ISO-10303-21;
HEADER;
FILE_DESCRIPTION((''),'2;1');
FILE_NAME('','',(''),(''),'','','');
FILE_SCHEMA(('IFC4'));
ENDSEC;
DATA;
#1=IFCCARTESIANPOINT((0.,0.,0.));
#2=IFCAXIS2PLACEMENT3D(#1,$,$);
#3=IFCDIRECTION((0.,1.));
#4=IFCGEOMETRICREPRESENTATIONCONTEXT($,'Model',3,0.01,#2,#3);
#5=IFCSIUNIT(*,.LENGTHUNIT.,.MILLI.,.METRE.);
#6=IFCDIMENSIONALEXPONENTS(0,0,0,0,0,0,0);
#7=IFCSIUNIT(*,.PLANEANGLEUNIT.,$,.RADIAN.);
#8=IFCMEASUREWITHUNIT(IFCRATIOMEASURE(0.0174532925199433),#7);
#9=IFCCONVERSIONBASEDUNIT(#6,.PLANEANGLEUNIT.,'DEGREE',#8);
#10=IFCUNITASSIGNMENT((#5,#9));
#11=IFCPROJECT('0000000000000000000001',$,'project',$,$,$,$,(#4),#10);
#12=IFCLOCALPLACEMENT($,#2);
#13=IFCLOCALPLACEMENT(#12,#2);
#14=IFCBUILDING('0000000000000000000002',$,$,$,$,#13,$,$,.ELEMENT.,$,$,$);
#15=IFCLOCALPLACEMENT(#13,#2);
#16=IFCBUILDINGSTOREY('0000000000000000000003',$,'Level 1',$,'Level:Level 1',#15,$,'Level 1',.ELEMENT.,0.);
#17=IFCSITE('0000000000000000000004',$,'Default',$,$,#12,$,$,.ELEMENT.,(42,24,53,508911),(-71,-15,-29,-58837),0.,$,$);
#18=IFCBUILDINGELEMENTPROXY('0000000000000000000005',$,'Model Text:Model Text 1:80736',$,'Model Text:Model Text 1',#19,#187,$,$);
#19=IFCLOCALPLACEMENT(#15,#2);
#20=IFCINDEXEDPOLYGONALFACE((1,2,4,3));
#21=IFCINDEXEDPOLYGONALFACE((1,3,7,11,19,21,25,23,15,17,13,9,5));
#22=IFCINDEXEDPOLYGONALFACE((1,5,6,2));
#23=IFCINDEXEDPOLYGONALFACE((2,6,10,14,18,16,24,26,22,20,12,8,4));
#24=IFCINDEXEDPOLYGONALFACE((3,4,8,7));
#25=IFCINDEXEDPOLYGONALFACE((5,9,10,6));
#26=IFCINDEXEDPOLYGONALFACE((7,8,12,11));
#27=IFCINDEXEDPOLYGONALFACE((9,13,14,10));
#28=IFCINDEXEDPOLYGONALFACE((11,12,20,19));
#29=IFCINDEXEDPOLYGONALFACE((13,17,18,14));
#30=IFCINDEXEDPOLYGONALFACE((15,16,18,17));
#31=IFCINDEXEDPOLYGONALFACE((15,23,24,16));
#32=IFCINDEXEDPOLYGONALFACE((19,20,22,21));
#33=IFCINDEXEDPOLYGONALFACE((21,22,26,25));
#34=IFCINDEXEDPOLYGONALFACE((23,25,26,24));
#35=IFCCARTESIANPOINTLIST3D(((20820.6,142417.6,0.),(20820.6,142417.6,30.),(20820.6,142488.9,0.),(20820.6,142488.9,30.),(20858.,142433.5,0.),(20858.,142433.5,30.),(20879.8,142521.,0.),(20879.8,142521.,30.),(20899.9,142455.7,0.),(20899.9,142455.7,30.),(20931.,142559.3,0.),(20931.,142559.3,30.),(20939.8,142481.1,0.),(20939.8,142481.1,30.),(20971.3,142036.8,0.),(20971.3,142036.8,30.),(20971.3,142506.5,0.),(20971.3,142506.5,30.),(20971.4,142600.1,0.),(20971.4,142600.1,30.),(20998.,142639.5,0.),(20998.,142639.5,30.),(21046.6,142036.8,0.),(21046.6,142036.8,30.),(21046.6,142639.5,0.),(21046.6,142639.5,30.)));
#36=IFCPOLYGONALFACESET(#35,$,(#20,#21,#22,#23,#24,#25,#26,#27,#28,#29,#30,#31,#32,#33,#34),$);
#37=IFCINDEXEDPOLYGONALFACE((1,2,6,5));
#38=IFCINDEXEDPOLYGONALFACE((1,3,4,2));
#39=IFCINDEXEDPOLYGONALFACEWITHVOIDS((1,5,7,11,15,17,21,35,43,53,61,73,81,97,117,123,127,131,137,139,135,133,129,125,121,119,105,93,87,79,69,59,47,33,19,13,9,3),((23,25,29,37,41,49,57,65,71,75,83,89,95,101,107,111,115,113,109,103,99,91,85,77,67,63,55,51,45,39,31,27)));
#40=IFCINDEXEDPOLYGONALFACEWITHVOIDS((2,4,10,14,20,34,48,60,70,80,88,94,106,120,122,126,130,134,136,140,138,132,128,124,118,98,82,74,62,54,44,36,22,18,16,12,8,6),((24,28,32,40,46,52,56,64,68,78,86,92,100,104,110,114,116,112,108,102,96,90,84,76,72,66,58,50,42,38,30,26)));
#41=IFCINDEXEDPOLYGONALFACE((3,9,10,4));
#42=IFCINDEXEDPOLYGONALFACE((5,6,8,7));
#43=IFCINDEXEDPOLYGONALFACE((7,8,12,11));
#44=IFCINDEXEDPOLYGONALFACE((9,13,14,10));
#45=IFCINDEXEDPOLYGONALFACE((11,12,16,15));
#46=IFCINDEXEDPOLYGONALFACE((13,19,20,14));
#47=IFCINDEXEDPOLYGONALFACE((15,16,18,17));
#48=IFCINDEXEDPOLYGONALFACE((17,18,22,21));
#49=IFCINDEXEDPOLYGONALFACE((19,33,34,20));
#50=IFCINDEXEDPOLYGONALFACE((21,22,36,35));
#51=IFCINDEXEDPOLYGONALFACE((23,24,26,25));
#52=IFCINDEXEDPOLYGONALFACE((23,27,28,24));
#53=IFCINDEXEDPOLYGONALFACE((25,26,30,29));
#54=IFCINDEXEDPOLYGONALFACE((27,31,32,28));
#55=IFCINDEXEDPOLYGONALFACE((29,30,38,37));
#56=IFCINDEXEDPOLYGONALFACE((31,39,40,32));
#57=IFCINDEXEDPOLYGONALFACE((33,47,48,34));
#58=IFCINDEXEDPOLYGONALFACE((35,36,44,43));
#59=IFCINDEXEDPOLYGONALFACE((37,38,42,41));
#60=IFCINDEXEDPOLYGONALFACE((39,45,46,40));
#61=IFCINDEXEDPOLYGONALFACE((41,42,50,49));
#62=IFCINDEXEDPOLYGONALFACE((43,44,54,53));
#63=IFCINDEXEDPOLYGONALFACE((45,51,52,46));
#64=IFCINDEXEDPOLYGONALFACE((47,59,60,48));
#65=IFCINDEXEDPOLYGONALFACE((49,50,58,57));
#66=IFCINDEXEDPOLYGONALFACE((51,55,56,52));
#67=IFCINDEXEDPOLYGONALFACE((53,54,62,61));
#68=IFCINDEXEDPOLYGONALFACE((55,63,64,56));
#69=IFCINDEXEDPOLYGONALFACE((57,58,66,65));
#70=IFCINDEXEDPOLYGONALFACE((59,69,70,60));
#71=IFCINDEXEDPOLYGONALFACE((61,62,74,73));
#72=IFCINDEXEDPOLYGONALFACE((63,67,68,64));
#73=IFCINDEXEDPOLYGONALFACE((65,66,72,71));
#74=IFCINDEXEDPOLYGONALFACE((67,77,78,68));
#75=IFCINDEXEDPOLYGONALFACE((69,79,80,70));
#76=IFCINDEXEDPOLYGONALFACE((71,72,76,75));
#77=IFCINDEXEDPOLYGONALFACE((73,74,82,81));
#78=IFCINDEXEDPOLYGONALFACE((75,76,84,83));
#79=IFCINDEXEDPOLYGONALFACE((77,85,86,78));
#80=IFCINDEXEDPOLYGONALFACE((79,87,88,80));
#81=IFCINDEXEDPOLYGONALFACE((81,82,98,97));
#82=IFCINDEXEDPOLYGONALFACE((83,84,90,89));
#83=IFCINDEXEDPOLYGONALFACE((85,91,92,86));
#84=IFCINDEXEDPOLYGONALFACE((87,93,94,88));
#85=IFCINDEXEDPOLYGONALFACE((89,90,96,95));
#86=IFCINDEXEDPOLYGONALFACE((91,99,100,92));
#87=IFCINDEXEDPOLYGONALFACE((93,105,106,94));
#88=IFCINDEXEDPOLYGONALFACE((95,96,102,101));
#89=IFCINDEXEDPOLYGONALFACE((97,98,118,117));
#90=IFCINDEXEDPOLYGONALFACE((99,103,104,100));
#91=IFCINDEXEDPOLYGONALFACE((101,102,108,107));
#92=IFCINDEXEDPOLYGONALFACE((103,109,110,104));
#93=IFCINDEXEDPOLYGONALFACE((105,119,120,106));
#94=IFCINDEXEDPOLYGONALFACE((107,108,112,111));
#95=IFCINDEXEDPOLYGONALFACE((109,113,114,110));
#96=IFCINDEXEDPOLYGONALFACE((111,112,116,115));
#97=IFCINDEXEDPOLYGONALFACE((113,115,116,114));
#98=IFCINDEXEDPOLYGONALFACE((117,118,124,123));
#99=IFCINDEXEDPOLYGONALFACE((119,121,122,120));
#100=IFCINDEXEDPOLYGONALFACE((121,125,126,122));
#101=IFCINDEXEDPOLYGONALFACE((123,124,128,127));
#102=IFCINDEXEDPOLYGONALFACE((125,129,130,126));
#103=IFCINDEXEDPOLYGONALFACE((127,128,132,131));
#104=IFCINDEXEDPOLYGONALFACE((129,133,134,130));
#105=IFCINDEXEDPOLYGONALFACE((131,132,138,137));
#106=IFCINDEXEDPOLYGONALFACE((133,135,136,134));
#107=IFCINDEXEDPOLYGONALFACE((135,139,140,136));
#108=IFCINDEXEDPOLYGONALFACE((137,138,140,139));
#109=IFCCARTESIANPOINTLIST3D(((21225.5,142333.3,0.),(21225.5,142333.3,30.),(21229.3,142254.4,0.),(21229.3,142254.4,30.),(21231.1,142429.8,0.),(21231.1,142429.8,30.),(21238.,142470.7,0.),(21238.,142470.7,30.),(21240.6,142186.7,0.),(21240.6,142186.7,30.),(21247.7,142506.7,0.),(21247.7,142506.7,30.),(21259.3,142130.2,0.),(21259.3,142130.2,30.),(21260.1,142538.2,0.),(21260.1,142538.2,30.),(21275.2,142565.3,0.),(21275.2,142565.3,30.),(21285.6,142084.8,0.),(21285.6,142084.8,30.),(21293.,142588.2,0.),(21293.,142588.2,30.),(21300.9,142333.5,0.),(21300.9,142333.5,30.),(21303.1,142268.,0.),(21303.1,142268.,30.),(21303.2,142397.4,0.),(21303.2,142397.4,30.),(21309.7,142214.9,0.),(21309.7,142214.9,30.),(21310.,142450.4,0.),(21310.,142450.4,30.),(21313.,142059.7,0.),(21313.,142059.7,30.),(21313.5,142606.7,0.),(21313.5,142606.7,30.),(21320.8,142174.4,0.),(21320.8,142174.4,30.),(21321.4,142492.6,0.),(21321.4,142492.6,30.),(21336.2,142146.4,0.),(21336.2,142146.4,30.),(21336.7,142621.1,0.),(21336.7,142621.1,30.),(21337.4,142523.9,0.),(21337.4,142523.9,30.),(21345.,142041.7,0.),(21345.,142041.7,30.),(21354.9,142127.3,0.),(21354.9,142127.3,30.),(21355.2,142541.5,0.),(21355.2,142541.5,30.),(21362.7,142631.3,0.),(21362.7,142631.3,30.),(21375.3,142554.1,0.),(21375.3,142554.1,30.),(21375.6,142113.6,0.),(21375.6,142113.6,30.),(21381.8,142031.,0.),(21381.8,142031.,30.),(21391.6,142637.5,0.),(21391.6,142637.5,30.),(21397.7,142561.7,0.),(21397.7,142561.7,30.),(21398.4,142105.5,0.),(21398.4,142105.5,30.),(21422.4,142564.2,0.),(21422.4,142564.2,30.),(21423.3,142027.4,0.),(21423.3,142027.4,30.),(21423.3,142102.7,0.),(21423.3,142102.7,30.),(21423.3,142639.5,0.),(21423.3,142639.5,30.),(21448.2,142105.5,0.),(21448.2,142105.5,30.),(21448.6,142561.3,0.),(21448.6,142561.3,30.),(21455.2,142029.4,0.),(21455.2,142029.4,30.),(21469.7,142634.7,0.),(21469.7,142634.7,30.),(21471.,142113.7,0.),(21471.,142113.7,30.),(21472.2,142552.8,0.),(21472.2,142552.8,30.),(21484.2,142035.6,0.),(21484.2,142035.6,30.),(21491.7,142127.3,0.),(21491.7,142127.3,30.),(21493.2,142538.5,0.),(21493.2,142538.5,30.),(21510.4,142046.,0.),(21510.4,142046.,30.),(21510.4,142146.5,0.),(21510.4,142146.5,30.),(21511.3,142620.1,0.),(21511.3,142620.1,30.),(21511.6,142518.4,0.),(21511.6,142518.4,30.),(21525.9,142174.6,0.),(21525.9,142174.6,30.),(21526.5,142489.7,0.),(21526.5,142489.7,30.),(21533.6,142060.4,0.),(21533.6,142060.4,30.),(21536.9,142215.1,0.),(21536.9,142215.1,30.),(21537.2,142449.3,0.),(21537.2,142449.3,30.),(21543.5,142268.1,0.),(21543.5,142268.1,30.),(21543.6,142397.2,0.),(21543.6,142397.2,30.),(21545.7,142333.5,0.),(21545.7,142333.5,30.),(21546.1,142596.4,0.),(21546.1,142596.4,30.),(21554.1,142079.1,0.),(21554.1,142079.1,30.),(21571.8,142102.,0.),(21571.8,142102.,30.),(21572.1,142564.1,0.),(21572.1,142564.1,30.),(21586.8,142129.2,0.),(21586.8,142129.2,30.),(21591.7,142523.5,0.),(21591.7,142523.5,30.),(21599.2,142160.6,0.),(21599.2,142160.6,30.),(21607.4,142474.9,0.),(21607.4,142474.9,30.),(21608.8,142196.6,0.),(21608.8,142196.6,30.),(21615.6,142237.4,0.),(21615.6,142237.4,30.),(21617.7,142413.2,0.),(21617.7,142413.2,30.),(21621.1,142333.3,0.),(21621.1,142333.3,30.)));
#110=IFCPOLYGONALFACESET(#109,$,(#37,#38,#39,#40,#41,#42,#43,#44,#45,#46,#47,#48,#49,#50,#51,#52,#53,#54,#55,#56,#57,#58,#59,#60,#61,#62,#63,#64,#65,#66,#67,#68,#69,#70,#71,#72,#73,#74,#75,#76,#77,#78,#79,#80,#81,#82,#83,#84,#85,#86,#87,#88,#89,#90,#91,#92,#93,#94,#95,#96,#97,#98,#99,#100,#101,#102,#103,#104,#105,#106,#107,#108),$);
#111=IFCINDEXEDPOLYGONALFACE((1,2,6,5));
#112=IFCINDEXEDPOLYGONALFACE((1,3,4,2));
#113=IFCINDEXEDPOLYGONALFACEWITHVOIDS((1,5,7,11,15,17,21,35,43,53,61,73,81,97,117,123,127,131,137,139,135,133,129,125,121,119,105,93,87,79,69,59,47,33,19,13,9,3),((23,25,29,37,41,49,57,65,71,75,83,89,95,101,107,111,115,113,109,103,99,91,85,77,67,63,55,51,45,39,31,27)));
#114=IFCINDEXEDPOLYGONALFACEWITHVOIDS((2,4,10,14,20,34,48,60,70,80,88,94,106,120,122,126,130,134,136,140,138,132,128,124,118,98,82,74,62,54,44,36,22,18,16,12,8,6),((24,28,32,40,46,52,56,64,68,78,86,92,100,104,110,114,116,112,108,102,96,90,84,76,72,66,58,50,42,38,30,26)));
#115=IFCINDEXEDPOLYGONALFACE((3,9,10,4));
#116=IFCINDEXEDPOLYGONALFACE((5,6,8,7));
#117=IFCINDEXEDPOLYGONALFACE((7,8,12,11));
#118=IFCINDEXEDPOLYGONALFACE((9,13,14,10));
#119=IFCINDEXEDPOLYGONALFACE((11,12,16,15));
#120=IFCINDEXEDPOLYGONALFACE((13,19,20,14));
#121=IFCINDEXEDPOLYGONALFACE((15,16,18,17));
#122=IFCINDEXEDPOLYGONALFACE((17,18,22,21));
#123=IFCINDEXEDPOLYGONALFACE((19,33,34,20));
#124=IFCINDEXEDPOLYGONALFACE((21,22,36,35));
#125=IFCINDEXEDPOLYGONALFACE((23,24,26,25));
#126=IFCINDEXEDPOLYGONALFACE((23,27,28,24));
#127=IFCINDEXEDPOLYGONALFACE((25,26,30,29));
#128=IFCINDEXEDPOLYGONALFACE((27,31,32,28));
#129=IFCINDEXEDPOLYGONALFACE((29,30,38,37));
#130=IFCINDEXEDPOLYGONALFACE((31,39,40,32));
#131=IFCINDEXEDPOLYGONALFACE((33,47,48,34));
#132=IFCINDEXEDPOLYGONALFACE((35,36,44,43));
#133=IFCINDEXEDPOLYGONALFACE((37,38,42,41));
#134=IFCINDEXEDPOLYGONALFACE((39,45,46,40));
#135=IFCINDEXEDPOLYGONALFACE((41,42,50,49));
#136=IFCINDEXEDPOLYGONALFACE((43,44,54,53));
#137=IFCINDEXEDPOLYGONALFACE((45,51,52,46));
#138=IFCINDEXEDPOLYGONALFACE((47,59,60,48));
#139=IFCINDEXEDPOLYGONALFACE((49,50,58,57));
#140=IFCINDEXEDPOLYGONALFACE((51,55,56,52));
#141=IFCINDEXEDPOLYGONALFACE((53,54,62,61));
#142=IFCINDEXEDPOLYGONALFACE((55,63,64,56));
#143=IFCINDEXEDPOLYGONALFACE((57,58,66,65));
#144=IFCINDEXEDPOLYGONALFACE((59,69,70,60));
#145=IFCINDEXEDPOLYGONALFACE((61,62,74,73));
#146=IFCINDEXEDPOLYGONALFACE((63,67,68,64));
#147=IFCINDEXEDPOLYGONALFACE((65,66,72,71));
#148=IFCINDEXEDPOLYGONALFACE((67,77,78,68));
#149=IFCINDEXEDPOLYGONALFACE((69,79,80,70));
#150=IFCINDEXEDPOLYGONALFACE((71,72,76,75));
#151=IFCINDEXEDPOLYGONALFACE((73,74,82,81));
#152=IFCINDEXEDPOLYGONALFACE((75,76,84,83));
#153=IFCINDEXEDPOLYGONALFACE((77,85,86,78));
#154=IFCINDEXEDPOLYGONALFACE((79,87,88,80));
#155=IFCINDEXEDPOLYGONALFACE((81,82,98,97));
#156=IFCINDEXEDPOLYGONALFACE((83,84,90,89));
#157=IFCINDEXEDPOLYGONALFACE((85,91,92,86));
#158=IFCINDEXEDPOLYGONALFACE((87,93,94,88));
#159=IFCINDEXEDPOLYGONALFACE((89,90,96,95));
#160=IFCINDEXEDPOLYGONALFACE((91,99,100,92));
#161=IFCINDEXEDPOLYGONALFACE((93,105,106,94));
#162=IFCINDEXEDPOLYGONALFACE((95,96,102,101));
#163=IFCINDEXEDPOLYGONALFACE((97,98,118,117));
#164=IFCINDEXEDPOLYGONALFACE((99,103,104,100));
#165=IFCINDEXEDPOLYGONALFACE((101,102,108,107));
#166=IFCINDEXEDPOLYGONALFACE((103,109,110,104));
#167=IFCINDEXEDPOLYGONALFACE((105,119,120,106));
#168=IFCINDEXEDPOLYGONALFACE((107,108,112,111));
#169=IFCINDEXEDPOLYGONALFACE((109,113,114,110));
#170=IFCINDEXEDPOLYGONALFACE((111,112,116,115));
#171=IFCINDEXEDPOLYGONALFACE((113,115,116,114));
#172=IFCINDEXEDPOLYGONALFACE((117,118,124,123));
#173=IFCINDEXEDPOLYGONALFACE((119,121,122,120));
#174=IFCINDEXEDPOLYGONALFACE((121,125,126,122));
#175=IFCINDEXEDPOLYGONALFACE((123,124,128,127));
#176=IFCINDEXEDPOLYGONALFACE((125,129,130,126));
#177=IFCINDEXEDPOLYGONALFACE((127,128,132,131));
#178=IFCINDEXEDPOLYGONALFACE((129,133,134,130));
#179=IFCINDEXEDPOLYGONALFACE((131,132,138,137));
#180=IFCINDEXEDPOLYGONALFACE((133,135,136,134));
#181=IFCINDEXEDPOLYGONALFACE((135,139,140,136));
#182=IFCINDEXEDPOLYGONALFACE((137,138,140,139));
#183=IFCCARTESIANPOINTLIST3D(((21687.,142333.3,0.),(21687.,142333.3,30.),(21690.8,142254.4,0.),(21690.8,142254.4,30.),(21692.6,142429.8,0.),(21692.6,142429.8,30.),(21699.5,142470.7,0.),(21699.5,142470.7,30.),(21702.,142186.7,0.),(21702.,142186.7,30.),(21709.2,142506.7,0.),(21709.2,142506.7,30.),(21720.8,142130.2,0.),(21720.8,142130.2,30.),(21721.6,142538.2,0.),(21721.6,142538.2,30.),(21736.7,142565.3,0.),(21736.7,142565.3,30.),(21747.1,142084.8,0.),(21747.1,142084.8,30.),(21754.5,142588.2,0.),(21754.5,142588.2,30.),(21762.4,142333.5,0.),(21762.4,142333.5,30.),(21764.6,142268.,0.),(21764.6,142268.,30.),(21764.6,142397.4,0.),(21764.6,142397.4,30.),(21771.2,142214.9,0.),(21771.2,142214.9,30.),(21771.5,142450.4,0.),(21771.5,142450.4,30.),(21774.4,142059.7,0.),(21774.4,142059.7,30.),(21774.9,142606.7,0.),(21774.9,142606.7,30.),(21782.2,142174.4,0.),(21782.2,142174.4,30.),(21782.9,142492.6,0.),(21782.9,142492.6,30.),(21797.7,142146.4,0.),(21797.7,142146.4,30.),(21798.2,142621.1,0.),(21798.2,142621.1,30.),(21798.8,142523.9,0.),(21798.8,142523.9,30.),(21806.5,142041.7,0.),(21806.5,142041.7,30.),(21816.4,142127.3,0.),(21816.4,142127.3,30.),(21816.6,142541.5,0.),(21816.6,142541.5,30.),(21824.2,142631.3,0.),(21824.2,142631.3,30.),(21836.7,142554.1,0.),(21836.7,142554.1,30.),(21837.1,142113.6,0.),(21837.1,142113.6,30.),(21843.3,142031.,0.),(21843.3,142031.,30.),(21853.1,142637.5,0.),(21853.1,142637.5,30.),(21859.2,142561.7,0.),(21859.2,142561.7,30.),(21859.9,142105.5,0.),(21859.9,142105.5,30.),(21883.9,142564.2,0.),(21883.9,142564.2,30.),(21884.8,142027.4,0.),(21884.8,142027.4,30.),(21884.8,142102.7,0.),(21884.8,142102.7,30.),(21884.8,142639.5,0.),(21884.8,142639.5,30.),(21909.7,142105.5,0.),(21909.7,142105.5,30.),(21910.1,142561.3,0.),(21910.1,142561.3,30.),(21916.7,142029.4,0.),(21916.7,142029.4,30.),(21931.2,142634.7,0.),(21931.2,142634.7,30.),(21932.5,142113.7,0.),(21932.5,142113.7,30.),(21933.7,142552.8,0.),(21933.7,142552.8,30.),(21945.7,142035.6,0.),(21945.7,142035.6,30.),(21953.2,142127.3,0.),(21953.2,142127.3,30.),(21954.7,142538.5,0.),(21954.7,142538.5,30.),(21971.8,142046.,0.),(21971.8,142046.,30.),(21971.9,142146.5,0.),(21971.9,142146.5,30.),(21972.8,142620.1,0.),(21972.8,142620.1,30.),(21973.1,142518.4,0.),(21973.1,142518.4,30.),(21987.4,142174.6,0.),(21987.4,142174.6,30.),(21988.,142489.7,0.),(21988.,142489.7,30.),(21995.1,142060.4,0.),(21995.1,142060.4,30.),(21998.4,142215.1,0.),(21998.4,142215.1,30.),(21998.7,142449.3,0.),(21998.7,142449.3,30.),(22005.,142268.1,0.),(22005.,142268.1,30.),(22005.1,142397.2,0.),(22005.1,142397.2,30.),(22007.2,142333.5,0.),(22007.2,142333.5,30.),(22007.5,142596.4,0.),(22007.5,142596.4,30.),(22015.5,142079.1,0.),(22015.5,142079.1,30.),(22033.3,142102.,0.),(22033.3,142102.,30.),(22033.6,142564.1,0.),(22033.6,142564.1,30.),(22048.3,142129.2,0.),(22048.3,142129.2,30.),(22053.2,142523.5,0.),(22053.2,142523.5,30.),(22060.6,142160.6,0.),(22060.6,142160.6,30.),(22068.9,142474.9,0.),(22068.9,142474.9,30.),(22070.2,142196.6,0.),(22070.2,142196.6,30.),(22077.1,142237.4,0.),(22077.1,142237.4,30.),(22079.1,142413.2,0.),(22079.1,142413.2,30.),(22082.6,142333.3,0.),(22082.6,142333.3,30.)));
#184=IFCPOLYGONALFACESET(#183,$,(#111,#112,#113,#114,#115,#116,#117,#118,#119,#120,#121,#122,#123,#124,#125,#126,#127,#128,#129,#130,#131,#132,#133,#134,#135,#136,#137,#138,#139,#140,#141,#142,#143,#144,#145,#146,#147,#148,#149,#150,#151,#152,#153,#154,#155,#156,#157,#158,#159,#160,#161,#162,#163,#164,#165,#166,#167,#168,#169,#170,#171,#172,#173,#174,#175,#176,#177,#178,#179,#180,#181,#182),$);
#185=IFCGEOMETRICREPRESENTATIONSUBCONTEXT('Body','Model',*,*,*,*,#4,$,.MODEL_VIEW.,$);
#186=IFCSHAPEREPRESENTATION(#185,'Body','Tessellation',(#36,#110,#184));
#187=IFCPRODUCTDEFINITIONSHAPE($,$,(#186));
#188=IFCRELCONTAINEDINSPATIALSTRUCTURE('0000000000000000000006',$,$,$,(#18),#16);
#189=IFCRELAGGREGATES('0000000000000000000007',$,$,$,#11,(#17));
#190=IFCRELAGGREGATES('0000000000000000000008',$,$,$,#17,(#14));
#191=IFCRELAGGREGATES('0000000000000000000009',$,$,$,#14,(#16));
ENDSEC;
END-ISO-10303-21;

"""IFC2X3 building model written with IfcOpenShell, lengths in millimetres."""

from ifc_helpers import new_model, entity, si_unit, converted_unit, direction, frame, origin, place, context, subcontext, project, spatial, polyline, outline, extrude, element, save


model = new_model("IFC2X3")

# Units and contexts
model_context = context("Model", 3, precision=0.01, world=origin(), true_north=direction((0.0, 1.0)))
body_context = subcontext(model_context, "Body", "Model", "MODEL_VIEW")
ifc_project = project(units=[si_unit("LENGTHUNIT", "METRE", prefix="MILLI"), converted_unit("PLANEANGLEUNIT", "DEGREE", entity("IfcRatioMeasure", 0.0174532925199433), si_unit("PLANEANGLEUNIT", "RADIAN"), dimensions=[0, 0, 0, 0, 0, 0, 0])], contexts=[model_context])

# Site, building, storey
site_placement = place(None, origin())
site = spatial("IfcSite", under=ifc_project, at=site_placement, Name="Default", CompositionType="ELEMENT", RefLatitude=(42, 24, 53, 508911), RefLongitude=(-71, -15, -29, -58837), RefElevation=0.0)
building_placement = place(site_placement, origin())
building = spatial("IfcBuilding", under=site, at=building_placement, CompositionType="ELEMENT")
storey_placement = place(building_placement, origin())
storey = spatial("IfcBuildingStorey", under=building, at=storey_placement, Name="Level 1", ObjectType="Level:Level 1", LongName="Level 1", CompositionType="ELEMENT", Elevation=0.0)

# Building element proxy
proxy_1_placement = place(storey_placement, origin())
element("IfcBuildingElementProxy", 1, at=proxy_1_placement, inside=storey, Name="Model Text:Model Text 1:80736", ObjectType="Model Text:Model Text 1", context=body_context, shape_type="SweptSolid", body=[
    extrude(outline(polyline([(-410.6, -111.6), (192.1, -111.6), (192.1, -63.1), (152.7, -36.4), (111.9, 4.0), (73.6, 55.2), (41.4, 114.4), (-29.8, 114.4), (-13.9, 77.0), (8.3, 35.1), (33.7, -4.8), (59.1, -36.3), (-410.6, -36.3), (-410.6, -111.6)])), frame((20935.0, 142447.4, 0.0), z_axis=(0.0, 0.0, 1.0), x_axis=(0.0, 1.0, 0.0)), (0.0, 0.0, 1.0), 30.0),
    extrude(outline(polyline([(-10.6, -198.7), (68.3, -198.7), (136.5, -190.7), (193.9, -174.7), (240.5, -150.6), (266.9, -124.4), (286.3, -93.2), (298.8, -57.0), (304.3, -15.7), (303.8, 16.2), (299.0, 45.5), (289.9, 72.1), (276.6, 96.0), (258.9, 117.3), (236.9, 136.2), (210.4, 152.5), (179.6, 166.3), (144.1, 177.6), (103.7, 186.3), (8.2, 196.4), (-71.8, 196.7), (-134.0, 189.4), (-183.3, 176.1), (-224.7, 158.4), (-258.2, 133.9), (-283.5, 100.3), (-300.1, 59.5), (-307.1, 13.4), (-306.6, -18.4), (-301.8, -47.5), (-292.8, -74.0), (-279.6, -97.9), (-262.0, -119.2), (-240.0, -138.1), (-213.6, -154.5), (-182.8, -168.4), (-147.3, -179.8), (-106.7, -188.6), (-10.6, -198.7)]), holes=[polyline([(-7.2, -123.5), (-71.0, -118.2), (-123.6, -108.8), (-165.2, -95.4), (-195.7, -78.0), (-212.4, -59.4), (-224.1, -38.7), (-230.6, -15.9), (-231.9, 8.9), (-227.8, 35.0), (-218.1, 58.1), (-202.8, 78.4), (-182.0, 95.8), (-152.6, 109.4), (-111.7, 118.1), (-59.4, 122.0), (4.4, 121.1), (69.6, 115.8), (122.2, 106.7), (162.2, 93.7), (189.5, 77.0), (207.7, 57.4), (220.4, 36.0), (227.5, 12.8), (229.1, -12.1), (225.2, -36.8), (215.9, -59.2), (201.3, -79.3), (181.4, -97.1), (152.6, -111.2), (111.6, -120.3), (58.3, -124.4), (-7.2, -123.5)])]), frame((21424.6, 142332.1, 0.0), z_axis=(0.0, 0.0, 1.0), x_axis=(0.047515, -0.998871, 0.0)), (0.0, 0.0, 1.0), 30.0),
    extrude(outline(polyline([(-10.6, -198.7), (68.3, -198.7), (136.5, -190.7), (193.9, -174.7), (240.5, -150.6), (266.9, -124.4), (286.3, -93.2), (298.8, -57.0), (304.3, -15.7), (303.8, 16.2), (299.0, 45.5), (289.9, 72.1), (276.6, 96.0), (258.9, 117.3), (236.9, 136.2), (210.4, 152.5), (179.6, 166.3), (144.1, 177.6), (103.7, 186.3), (8.2, 196.4), (-71.8, 196.7), (-134.0, 189.4), (-183.3, 176.1), (-224.7, 158.4), (-258.2, 133.9), (-283.5, 100.3), (-300.1, 59.5), (-307.1, 13.4), (-306.6, -18.4), (-301.8, -47.5), (-292.8, -74.0), (-279.6, -97.9), (-262.0, -119.2), (-240.0, -138.1), (-213.6, -154.5), (-182.8, -168.4), (-147.3, -179.8), (-106.7, -188.6), (-10.6, -198.7)]), holes=[polyline([(-7.2, -123.5), (-71.0, -118.2), (-123.6, -108.8), (-165.2, -95.4), (-195.7, -78.0), (-212.4, -59.4), (-224.1, -38.7), (-230.6, -15.9), (-231.9, 8.9), (-227.8, 35.0), (-218.1, 58.1), (-202.8, 78.4), (-182.0, 95.8), (-152.6, 109.4), (-111.7, 118.1), (-59.4, 122.0), (4.4, 121.1), (69.6, 115.8), (122.2, 106.7), (162.2, 93.7), (189.5, 77.0), (207.7, 57.4), (220.4, 36.0), (227.5, 12.8), (229.1, -12.1), (225.2, -36.8), (215.9, -59.2), (201.3, -79.3), (181.4, -97.1), (152.6, -111.2), (111.6, -120.3), (58.3, -124.4), (-7.2, -123.5)])]), frame((21886.0, 142332.1, 0.0), z_axis=(0.0, 0.0, 1.0), x_axis=(0.047515, -0.998871, 0.0)), (0.0, 0.0, 1.0), 30.0),
])

save(model, "model.ifc")
